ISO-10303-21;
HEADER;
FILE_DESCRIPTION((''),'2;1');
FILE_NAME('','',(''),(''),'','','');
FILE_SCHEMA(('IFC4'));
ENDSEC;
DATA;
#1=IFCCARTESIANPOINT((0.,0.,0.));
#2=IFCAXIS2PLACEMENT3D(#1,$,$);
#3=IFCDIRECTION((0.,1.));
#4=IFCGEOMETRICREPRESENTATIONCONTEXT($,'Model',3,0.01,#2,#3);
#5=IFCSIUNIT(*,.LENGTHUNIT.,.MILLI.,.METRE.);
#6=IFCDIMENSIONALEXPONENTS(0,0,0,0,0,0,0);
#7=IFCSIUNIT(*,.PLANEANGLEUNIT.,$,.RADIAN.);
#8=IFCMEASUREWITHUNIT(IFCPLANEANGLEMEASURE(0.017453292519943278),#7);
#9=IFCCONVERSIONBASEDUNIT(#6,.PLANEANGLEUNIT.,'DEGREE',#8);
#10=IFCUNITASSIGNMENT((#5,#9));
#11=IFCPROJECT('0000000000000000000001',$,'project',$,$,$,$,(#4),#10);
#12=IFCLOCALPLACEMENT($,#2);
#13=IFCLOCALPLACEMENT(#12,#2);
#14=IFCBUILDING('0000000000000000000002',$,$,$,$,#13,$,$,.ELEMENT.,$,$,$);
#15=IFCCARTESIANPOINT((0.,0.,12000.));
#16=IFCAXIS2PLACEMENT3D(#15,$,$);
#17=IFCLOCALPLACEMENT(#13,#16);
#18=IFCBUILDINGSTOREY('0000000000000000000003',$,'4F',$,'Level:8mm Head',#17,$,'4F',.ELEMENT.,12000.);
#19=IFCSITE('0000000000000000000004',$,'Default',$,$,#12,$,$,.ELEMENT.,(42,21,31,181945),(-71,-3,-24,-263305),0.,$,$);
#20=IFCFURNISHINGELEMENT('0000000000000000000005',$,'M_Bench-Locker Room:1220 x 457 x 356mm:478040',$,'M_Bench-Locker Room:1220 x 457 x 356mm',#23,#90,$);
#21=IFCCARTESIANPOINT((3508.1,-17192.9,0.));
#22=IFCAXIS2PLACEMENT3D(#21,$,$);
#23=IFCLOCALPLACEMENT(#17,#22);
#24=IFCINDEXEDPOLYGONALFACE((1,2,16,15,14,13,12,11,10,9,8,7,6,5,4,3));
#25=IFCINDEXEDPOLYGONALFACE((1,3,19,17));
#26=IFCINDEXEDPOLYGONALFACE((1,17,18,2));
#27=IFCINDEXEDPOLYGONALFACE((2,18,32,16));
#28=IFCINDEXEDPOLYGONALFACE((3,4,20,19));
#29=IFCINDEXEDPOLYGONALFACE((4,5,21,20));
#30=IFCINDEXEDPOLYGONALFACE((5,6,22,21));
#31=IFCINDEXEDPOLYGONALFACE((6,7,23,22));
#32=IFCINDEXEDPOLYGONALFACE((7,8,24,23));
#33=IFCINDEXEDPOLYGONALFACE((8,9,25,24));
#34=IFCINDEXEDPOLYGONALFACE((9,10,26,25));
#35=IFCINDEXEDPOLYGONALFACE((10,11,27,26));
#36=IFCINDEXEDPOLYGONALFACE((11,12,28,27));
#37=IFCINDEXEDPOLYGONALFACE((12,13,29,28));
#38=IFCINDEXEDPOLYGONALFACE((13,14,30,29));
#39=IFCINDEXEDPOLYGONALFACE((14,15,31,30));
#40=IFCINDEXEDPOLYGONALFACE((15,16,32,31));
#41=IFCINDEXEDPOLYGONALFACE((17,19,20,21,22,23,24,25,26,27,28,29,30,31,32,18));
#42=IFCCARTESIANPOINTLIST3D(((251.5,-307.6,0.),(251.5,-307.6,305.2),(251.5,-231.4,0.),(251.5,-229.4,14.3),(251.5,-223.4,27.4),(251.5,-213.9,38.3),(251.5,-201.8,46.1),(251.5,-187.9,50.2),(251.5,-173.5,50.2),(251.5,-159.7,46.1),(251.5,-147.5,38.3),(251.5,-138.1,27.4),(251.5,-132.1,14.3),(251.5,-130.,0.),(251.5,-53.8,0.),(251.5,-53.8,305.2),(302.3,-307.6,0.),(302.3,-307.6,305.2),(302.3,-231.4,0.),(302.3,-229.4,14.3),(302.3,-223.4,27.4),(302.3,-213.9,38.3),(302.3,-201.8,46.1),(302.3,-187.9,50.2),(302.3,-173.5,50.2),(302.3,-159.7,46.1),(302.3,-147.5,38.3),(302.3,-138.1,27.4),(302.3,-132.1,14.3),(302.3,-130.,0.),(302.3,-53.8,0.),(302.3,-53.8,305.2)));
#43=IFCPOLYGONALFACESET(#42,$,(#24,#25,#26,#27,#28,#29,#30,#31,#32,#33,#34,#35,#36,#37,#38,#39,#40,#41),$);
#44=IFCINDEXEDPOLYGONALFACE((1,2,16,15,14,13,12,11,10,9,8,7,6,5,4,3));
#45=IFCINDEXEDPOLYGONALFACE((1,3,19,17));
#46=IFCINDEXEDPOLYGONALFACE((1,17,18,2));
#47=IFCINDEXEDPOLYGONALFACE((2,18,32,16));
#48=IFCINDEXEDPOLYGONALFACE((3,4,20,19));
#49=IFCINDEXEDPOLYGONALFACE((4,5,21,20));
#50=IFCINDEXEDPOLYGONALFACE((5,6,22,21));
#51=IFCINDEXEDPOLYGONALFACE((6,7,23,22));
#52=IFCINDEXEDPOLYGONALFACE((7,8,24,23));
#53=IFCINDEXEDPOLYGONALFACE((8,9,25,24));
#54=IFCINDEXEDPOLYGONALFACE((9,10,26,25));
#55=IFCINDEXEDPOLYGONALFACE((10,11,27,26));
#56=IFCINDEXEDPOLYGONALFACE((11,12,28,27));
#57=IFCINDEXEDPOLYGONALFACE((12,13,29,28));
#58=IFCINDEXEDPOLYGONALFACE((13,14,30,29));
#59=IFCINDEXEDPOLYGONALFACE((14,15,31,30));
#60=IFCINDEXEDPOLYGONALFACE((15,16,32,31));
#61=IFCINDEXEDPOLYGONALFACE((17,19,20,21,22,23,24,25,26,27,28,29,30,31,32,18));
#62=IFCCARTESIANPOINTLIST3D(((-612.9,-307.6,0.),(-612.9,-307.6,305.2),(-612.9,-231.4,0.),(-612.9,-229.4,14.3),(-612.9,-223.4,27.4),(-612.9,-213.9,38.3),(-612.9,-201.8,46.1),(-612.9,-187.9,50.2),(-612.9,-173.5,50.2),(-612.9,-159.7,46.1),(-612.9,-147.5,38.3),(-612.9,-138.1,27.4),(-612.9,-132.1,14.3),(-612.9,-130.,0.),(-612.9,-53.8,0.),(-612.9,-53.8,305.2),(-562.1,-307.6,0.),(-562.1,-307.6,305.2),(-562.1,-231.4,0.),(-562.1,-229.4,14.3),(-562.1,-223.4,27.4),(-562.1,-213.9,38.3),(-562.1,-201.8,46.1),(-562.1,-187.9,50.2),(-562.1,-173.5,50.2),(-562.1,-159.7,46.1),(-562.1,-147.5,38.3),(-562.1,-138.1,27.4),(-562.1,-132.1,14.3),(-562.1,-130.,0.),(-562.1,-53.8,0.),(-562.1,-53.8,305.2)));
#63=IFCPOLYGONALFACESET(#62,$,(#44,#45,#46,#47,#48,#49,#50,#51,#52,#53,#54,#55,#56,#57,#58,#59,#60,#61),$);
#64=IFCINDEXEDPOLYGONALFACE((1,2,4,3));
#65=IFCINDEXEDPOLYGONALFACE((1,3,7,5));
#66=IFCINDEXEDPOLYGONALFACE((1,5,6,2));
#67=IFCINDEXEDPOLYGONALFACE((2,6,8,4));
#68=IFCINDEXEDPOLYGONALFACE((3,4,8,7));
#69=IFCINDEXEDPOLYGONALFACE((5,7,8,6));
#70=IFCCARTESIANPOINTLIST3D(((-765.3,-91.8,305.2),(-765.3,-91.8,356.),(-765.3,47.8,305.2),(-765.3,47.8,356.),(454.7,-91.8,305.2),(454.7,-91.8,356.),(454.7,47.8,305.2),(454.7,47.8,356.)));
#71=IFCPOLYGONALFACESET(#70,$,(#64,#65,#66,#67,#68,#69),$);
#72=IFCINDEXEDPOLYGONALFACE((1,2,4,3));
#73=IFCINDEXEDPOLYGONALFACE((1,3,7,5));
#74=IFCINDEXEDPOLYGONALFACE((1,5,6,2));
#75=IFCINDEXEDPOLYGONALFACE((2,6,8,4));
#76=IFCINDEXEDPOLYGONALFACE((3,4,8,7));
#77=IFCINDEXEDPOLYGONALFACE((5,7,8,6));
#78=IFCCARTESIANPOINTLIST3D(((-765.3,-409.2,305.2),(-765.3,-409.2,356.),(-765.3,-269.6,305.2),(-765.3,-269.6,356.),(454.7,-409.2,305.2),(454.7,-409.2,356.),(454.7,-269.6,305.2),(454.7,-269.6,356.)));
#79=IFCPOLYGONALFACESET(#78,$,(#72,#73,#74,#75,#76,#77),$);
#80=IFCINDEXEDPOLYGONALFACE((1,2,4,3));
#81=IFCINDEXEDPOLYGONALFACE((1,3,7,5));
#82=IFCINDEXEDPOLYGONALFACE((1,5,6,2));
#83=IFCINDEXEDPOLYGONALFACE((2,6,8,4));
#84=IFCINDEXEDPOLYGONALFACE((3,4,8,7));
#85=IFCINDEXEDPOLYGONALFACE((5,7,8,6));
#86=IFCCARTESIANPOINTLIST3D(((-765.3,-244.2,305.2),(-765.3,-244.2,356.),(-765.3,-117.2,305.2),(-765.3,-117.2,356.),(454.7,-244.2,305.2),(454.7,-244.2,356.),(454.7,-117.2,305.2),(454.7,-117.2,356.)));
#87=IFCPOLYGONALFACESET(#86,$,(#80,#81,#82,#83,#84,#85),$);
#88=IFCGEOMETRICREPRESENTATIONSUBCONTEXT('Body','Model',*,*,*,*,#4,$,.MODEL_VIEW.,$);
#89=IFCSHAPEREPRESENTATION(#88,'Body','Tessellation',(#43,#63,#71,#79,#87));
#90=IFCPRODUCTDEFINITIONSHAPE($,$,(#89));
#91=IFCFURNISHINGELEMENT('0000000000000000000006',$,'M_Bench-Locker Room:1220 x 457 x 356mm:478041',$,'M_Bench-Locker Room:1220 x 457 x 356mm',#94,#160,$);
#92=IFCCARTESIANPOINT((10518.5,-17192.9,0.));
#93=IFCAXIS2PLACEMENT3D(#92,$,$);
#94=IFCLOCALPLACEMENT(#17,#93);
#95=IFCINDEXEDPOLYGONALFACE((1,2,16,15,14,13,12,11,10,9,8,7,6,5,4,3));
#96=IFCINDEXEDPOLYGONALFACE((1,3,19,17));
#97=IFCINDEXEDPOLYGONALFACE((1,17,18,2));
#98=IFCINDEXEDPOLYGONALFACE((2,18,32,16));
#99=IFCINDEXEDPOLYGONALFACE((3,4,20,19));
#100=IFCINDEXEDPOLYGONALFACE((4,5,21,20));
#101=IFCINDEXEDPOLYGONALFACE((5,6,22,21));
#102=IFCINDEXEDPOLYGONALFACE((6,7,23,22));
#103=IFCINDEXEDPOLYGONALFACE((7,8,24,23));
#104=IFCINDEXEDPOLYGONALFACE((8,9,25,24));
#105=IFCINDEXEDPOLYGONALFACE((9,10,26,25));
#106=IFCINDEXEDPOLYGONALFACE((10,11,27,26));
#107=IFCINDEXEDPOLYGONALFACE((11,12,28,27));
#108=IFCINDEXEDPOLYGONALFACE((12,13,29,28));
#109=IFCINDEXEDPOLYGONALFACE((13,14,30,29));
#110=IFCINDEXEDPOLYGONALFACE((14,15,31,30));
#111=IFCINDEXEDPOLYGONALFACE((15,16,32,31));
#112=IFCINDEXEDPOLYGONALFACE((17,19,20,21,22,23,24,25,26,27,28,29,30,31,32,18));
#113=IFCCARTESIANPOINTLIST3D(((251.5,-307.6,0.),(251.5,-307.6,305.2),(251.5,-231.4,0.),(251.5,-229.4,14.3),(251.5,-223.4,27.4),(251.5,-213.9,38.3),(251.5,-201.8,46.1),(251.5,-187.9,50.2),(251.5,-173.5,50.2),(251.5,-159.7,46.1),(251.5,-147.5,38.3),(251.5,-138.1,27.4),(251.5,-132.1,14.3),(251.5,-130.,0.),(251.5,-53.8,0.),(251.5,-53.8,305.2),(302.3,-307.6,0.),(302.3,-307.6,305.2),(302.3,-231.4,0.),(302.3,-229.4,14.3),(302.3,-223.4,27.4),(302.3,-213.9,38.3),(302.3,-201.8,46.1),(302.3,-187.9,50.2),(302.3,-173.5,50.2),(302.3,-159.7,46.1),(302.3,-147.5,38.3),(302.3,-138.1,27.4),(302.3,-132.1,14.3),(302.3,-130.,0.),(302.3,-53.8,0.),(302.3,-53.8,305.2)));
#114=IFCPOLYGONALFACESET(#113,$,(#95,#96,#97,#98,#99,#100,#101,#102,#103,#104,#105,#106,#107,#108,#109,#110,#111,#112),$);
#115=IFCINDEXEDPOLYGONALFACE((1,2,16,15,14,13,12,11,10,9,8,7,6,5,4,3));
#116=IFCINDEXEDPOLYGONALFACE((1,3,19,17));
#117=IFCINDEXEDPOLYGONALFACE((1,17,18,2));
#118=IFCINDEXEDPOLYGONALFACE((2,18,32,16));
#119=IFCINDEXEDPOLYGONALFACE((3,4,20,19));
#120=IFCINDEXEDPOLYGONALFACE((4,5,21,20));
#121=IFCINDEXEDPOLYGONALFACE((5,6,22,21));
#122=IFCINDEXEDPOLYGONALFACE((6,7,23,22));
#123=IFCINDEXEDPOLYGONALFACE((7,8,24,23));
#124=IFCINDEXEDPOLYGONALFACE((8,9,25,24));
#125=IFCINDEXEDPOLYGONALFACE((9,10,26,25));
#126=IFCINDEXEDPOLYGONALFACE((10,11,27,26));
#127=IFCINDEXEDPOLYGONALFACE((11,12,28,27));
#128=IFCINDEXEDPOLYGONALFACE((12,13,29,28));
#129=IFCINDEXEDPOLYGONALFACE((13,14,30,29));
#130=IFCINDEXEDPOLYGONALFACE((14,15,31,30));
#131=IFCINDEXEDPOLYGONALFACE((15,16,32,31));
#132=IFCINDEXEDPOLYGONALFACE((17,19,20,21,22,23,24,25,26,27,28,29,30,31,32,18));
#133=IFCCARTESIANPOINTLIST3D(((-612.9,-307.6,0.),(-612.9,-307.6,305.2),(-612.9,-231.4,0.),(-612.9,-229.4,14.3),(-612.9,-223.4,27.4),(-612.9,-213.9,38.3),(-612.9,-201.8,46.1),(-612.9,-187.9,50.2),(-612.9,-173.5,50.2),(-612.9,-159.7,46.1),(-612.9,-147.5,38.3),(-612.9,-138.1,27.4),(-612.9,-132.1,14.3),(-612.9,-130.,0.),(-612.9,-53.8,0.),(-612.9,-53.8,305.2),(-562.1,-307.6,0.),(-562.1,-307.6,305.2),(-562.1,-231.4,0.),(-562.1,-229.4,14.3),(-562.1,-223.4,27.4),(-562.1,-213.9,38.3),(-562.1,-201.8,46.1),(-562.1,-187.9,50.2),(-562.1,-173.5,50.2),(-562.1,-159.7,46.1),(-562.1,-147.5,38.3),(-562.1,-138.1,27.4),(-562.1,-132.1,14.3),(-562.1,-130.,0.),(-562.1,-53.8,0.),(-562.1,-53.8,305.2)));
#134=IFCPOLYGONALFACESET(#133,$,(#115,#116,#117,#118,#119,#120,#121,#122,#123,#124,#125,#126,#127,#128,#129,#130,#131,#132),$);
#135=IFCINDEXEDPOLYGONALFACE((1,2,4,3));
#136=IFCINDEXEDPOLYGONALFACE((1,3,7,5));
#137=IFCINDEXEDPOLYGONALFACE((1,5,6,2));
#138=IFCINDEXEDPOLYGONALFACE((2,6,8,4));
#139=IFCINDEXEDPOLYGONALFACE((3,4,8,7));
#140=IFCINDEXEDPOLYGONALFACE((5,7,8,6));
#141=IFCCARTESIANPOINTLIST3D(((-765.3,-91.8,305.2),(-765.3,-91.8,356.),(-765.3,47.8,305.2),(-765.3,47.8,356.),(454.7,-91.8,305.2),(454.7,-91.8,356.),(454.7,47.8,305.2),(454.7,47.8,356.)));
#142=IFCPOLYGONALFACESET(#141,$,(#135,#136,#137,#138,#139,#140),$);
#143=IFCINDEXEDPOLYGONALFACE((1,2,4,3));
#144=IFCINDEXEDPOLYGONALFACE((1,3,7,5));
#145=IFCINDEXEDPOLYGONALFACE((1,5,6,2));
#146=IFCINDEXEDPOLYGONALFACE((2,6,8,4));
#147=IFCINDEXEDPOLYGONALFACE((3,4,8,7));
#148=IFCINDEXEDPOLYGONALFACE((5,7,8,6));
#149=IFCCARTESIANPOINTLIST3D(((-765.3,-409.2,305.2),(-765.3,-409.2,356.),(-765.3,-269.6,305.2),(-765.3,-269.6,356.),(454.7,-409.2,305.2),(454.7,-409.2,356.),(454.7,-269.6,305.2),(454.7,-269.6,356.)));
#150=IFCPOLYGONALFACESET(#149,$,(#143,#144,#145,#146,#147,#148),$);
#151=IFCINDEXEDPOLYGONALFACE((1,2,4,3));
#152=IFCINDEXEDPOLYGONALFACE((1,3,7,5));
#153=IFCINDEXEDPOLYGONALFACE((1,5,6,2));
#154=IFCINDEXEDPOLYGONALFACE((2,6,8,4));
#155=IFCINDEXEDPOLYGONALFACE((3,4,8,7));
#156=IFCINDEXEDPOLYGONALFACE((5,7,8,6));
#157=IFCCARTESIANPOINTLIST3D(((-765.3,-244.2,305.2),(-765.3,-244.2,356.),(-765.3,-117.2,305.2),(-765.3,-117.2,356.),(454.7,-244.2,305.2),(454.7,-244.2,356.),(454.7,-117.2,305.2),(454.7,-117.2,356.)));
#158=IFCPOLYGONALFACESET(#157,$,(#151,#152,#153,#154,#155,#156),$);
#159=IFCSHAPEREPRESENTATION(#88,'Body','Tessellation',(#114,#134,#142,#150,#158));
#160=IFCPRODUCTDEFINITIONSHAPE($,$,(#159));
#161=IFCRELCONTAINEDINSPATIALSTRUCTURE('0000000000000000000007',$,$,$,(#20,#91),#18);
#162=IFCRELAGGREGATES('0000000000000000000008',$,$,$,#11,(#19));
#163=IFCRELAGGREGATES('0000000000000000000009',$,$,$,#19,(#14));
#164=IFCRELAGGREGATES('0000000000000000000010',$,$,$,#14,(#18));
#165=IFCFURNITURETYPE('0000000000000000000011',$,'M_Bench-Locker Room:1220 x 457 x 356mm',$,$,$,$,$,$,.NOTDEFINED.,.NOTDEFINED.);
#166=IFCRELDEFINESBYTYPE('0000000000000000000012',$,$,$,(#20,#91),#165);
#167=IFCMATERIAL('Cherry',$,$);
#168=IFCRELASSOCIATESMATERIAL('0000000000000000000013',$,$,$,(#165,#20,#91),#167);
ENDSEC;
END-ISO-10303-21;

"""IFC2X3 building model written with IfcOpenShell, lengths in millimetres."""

from ifc_helpers import new_model, entity, si_unit, converted_unit, direction, frame, frame_2d, origin, origin_2d_with_axis, place, context, subcontext, project, spatial, polyline, circle_curve, parameter, trimmed, segment, composite_curve, rectangle, outline, extrude, source, transform, mapped, material, type_object, type_shapes, element, save


model = new_model("IFC2X3")

# Units and contexts
model_context = context("Model", 3, precision=0.01, world=origin(), true_north=direction((0.0, 1.0)))
body_context = subcontext(model_context, "Body", "Model", "MODEL_VIEW")
ifc_project = project(units=[si_unit("LENGTHUNIT", "METRE", prefix="MILLI"), converted_unit("PLANEANGLEUNIT", "DEGREE", entity("IfcPlaneAngleMeasure", 0.017453292519943278), si_unit("PLANEANGLEUNIT", "RADIAN"), dimensions=[0, 0, 0, 0, 0, 0, 0])], contexts=[model_context])

# Site, building, storey
site_placement = place(None, origin())
site = spatial("IfcSite", under=ifc_project, at=site_placement, Name="Default", CompositionType="ELEMENT", RefLatitude=(42, 21, 31, 181945), RefLongitude=(-71, -3, -24, -263305), RefElevation=0.0)
building_placement = place(site_placement, origin())
building = spatial("IfcBuilding", under=site, at=building_placement, CompositionType="ELEMENT")
storey_placement = place(building_placement, frame((0.0, 0.0, 12000.0)))
storey = spatial("IfcBuildingStorey", under=building, at=storey_placement, Name="4F", ObjectType="Level:8mm Head", LongName="4F", CompositionType="ELEMENT", Elevation=12000.0)

# Furnishing elements
ifc_material_1 = material(Name="Cherry")
furniture_type = type_object("IfcFurnitureType", Name="M_Bench-Locker Room:1220 x 457 x 356mm", AssemblyPlace="NOTDEFINED", material=ifc_material_1)
shared_shape = source(origin(), body_context, "Body", "SweptSolid", [
    extrude(outline(composite_curve([segment(polyline([(-126.9, 101.7), (-126.9, -203.5)]), True, "CONTINUOUS"), segment(polyline([(-126.9, -203.5), (126.9, -203.5)]), True, "CONTINUOUS"), segment(polyline([(126.9, -203.5), (126.9, 101.7)]), True, "CONTINUOUS"), segment(polyline([(126.9, 101.7), (50.7, 101.7)]), True, "CONTINUOUS"), segment(trimmed(circle_curve(frame_2d((0.0, 101.7), x_axis=(0.0, 1.0)), 50.7), [parameter(90.0)], [parameter(270.0)], True, "PARAMETER"), False, "CONTINUOUS"), segment(polyline([(-50.7, 101.7), (-126.9, 101.7)]), True, "CONTINUOUS")], self_intersect=False)), frame((251.5, -180.7, 101.7), z_axis=(-1.0, 0.0, 0.0), x_axis=(0.0, 1.0, 0.0)), (0.0, 0.0, -1.0), 50.8),
    extrude(outline(composite_curve([segment(polyline([(-101.7, -126.9), (203.5, -126.9)]), True, "CONTINUOUS"), segment(polyline([(203.5, -126.9), (203.5, 126.9)]), True, "CONTINUOUS"), segment(polyline([(203.5, 126.9), (-101.7, 126.9)]), True, "CONTINUOUS"), segment(polyline([(-101.7, 126.9), (-101.7, 50.7)]), True, "CONTINUOUS"), segment(trimmed(circle_curve(frame_2d((-101.7, 0.0), x_axis=(-1.0, 0.0)), 50.7), [parameter(90.0)], [parameter(270.0)], True, "PARAMETER"), False, "CONTINUOUS"), segment(polyline([(-101.7, -50.7), (-101.7, -126.9)]), True, "CONTINUOUS")], self_intersect=False)), frame((-612.9, -180.7, 101.7), z_axis=(1.0, 0.0, 0.0), x_axis=(0.0, 0.0, 1.0)), (0.0, 0.0, 1.0), 50.8),
    extrude(rectangle(XDim=1220.0, YDim=139.6, at=origin_2d_with_axis()), frame((-155.3, -22.0, 305.2), z_axis=(0.0, 0.0, 1.0), x_axis=(-1.0, 0.0, 0.0)), (0.0, 0.0, 1.0), 50.8),
    extrude(rectangle(XDim=139.6, YDim=1220.0, at=frame_2d((0.0, 0.0), x_axis=(1.0, 0.0))), frame((-155.3, -339.4, 305.2), z_axis=(0.0, 0.0, 1.0), x_axis=(0.0, 1.0, 0.0)), (0.0, 0.0, 1.0), 50.8),
    extrude(rectangle(XDim=1220.0, YDim=126.9, at=frame_2d((0.0, 0.0), x_axis=(1.0, 0.0))), frame((-155.3, -180.7, 305.2), z_axis=(0.0, 0.0, 1.0), x_axis=(-1.0, 0.0, 0.0)), (0.0, 0.0, 1.0), 50.8),
])
type_shapes(furniture_type, [shared_shape])
for number, where, name in (
    (1, (3508.1, -17192.9, 0.0), "M_Bench-Locker Room:1220 x 457 x 356mm:478040"),
    (2, (10518.5, -17192.9, 0.0), "M_Bench-Locker Room:1220 x 457 x 356mm:478041"),
):
    element("IfcFurnishingElement", number, at=place(storey_placement, frame(where)), inside=storey, type_object=furniture_type, material=ifc_material_1, Name=name, ObjectType="M_Bench-Locker Room:1220 x 457 x 356mm", context=body_context, shape_type="MappedRepresentation", body=[
        mapped(shared_shape, transform((0.0, 0.0, 0.0), scale=1.0)),
    ])

save(model, "model.ifc")
